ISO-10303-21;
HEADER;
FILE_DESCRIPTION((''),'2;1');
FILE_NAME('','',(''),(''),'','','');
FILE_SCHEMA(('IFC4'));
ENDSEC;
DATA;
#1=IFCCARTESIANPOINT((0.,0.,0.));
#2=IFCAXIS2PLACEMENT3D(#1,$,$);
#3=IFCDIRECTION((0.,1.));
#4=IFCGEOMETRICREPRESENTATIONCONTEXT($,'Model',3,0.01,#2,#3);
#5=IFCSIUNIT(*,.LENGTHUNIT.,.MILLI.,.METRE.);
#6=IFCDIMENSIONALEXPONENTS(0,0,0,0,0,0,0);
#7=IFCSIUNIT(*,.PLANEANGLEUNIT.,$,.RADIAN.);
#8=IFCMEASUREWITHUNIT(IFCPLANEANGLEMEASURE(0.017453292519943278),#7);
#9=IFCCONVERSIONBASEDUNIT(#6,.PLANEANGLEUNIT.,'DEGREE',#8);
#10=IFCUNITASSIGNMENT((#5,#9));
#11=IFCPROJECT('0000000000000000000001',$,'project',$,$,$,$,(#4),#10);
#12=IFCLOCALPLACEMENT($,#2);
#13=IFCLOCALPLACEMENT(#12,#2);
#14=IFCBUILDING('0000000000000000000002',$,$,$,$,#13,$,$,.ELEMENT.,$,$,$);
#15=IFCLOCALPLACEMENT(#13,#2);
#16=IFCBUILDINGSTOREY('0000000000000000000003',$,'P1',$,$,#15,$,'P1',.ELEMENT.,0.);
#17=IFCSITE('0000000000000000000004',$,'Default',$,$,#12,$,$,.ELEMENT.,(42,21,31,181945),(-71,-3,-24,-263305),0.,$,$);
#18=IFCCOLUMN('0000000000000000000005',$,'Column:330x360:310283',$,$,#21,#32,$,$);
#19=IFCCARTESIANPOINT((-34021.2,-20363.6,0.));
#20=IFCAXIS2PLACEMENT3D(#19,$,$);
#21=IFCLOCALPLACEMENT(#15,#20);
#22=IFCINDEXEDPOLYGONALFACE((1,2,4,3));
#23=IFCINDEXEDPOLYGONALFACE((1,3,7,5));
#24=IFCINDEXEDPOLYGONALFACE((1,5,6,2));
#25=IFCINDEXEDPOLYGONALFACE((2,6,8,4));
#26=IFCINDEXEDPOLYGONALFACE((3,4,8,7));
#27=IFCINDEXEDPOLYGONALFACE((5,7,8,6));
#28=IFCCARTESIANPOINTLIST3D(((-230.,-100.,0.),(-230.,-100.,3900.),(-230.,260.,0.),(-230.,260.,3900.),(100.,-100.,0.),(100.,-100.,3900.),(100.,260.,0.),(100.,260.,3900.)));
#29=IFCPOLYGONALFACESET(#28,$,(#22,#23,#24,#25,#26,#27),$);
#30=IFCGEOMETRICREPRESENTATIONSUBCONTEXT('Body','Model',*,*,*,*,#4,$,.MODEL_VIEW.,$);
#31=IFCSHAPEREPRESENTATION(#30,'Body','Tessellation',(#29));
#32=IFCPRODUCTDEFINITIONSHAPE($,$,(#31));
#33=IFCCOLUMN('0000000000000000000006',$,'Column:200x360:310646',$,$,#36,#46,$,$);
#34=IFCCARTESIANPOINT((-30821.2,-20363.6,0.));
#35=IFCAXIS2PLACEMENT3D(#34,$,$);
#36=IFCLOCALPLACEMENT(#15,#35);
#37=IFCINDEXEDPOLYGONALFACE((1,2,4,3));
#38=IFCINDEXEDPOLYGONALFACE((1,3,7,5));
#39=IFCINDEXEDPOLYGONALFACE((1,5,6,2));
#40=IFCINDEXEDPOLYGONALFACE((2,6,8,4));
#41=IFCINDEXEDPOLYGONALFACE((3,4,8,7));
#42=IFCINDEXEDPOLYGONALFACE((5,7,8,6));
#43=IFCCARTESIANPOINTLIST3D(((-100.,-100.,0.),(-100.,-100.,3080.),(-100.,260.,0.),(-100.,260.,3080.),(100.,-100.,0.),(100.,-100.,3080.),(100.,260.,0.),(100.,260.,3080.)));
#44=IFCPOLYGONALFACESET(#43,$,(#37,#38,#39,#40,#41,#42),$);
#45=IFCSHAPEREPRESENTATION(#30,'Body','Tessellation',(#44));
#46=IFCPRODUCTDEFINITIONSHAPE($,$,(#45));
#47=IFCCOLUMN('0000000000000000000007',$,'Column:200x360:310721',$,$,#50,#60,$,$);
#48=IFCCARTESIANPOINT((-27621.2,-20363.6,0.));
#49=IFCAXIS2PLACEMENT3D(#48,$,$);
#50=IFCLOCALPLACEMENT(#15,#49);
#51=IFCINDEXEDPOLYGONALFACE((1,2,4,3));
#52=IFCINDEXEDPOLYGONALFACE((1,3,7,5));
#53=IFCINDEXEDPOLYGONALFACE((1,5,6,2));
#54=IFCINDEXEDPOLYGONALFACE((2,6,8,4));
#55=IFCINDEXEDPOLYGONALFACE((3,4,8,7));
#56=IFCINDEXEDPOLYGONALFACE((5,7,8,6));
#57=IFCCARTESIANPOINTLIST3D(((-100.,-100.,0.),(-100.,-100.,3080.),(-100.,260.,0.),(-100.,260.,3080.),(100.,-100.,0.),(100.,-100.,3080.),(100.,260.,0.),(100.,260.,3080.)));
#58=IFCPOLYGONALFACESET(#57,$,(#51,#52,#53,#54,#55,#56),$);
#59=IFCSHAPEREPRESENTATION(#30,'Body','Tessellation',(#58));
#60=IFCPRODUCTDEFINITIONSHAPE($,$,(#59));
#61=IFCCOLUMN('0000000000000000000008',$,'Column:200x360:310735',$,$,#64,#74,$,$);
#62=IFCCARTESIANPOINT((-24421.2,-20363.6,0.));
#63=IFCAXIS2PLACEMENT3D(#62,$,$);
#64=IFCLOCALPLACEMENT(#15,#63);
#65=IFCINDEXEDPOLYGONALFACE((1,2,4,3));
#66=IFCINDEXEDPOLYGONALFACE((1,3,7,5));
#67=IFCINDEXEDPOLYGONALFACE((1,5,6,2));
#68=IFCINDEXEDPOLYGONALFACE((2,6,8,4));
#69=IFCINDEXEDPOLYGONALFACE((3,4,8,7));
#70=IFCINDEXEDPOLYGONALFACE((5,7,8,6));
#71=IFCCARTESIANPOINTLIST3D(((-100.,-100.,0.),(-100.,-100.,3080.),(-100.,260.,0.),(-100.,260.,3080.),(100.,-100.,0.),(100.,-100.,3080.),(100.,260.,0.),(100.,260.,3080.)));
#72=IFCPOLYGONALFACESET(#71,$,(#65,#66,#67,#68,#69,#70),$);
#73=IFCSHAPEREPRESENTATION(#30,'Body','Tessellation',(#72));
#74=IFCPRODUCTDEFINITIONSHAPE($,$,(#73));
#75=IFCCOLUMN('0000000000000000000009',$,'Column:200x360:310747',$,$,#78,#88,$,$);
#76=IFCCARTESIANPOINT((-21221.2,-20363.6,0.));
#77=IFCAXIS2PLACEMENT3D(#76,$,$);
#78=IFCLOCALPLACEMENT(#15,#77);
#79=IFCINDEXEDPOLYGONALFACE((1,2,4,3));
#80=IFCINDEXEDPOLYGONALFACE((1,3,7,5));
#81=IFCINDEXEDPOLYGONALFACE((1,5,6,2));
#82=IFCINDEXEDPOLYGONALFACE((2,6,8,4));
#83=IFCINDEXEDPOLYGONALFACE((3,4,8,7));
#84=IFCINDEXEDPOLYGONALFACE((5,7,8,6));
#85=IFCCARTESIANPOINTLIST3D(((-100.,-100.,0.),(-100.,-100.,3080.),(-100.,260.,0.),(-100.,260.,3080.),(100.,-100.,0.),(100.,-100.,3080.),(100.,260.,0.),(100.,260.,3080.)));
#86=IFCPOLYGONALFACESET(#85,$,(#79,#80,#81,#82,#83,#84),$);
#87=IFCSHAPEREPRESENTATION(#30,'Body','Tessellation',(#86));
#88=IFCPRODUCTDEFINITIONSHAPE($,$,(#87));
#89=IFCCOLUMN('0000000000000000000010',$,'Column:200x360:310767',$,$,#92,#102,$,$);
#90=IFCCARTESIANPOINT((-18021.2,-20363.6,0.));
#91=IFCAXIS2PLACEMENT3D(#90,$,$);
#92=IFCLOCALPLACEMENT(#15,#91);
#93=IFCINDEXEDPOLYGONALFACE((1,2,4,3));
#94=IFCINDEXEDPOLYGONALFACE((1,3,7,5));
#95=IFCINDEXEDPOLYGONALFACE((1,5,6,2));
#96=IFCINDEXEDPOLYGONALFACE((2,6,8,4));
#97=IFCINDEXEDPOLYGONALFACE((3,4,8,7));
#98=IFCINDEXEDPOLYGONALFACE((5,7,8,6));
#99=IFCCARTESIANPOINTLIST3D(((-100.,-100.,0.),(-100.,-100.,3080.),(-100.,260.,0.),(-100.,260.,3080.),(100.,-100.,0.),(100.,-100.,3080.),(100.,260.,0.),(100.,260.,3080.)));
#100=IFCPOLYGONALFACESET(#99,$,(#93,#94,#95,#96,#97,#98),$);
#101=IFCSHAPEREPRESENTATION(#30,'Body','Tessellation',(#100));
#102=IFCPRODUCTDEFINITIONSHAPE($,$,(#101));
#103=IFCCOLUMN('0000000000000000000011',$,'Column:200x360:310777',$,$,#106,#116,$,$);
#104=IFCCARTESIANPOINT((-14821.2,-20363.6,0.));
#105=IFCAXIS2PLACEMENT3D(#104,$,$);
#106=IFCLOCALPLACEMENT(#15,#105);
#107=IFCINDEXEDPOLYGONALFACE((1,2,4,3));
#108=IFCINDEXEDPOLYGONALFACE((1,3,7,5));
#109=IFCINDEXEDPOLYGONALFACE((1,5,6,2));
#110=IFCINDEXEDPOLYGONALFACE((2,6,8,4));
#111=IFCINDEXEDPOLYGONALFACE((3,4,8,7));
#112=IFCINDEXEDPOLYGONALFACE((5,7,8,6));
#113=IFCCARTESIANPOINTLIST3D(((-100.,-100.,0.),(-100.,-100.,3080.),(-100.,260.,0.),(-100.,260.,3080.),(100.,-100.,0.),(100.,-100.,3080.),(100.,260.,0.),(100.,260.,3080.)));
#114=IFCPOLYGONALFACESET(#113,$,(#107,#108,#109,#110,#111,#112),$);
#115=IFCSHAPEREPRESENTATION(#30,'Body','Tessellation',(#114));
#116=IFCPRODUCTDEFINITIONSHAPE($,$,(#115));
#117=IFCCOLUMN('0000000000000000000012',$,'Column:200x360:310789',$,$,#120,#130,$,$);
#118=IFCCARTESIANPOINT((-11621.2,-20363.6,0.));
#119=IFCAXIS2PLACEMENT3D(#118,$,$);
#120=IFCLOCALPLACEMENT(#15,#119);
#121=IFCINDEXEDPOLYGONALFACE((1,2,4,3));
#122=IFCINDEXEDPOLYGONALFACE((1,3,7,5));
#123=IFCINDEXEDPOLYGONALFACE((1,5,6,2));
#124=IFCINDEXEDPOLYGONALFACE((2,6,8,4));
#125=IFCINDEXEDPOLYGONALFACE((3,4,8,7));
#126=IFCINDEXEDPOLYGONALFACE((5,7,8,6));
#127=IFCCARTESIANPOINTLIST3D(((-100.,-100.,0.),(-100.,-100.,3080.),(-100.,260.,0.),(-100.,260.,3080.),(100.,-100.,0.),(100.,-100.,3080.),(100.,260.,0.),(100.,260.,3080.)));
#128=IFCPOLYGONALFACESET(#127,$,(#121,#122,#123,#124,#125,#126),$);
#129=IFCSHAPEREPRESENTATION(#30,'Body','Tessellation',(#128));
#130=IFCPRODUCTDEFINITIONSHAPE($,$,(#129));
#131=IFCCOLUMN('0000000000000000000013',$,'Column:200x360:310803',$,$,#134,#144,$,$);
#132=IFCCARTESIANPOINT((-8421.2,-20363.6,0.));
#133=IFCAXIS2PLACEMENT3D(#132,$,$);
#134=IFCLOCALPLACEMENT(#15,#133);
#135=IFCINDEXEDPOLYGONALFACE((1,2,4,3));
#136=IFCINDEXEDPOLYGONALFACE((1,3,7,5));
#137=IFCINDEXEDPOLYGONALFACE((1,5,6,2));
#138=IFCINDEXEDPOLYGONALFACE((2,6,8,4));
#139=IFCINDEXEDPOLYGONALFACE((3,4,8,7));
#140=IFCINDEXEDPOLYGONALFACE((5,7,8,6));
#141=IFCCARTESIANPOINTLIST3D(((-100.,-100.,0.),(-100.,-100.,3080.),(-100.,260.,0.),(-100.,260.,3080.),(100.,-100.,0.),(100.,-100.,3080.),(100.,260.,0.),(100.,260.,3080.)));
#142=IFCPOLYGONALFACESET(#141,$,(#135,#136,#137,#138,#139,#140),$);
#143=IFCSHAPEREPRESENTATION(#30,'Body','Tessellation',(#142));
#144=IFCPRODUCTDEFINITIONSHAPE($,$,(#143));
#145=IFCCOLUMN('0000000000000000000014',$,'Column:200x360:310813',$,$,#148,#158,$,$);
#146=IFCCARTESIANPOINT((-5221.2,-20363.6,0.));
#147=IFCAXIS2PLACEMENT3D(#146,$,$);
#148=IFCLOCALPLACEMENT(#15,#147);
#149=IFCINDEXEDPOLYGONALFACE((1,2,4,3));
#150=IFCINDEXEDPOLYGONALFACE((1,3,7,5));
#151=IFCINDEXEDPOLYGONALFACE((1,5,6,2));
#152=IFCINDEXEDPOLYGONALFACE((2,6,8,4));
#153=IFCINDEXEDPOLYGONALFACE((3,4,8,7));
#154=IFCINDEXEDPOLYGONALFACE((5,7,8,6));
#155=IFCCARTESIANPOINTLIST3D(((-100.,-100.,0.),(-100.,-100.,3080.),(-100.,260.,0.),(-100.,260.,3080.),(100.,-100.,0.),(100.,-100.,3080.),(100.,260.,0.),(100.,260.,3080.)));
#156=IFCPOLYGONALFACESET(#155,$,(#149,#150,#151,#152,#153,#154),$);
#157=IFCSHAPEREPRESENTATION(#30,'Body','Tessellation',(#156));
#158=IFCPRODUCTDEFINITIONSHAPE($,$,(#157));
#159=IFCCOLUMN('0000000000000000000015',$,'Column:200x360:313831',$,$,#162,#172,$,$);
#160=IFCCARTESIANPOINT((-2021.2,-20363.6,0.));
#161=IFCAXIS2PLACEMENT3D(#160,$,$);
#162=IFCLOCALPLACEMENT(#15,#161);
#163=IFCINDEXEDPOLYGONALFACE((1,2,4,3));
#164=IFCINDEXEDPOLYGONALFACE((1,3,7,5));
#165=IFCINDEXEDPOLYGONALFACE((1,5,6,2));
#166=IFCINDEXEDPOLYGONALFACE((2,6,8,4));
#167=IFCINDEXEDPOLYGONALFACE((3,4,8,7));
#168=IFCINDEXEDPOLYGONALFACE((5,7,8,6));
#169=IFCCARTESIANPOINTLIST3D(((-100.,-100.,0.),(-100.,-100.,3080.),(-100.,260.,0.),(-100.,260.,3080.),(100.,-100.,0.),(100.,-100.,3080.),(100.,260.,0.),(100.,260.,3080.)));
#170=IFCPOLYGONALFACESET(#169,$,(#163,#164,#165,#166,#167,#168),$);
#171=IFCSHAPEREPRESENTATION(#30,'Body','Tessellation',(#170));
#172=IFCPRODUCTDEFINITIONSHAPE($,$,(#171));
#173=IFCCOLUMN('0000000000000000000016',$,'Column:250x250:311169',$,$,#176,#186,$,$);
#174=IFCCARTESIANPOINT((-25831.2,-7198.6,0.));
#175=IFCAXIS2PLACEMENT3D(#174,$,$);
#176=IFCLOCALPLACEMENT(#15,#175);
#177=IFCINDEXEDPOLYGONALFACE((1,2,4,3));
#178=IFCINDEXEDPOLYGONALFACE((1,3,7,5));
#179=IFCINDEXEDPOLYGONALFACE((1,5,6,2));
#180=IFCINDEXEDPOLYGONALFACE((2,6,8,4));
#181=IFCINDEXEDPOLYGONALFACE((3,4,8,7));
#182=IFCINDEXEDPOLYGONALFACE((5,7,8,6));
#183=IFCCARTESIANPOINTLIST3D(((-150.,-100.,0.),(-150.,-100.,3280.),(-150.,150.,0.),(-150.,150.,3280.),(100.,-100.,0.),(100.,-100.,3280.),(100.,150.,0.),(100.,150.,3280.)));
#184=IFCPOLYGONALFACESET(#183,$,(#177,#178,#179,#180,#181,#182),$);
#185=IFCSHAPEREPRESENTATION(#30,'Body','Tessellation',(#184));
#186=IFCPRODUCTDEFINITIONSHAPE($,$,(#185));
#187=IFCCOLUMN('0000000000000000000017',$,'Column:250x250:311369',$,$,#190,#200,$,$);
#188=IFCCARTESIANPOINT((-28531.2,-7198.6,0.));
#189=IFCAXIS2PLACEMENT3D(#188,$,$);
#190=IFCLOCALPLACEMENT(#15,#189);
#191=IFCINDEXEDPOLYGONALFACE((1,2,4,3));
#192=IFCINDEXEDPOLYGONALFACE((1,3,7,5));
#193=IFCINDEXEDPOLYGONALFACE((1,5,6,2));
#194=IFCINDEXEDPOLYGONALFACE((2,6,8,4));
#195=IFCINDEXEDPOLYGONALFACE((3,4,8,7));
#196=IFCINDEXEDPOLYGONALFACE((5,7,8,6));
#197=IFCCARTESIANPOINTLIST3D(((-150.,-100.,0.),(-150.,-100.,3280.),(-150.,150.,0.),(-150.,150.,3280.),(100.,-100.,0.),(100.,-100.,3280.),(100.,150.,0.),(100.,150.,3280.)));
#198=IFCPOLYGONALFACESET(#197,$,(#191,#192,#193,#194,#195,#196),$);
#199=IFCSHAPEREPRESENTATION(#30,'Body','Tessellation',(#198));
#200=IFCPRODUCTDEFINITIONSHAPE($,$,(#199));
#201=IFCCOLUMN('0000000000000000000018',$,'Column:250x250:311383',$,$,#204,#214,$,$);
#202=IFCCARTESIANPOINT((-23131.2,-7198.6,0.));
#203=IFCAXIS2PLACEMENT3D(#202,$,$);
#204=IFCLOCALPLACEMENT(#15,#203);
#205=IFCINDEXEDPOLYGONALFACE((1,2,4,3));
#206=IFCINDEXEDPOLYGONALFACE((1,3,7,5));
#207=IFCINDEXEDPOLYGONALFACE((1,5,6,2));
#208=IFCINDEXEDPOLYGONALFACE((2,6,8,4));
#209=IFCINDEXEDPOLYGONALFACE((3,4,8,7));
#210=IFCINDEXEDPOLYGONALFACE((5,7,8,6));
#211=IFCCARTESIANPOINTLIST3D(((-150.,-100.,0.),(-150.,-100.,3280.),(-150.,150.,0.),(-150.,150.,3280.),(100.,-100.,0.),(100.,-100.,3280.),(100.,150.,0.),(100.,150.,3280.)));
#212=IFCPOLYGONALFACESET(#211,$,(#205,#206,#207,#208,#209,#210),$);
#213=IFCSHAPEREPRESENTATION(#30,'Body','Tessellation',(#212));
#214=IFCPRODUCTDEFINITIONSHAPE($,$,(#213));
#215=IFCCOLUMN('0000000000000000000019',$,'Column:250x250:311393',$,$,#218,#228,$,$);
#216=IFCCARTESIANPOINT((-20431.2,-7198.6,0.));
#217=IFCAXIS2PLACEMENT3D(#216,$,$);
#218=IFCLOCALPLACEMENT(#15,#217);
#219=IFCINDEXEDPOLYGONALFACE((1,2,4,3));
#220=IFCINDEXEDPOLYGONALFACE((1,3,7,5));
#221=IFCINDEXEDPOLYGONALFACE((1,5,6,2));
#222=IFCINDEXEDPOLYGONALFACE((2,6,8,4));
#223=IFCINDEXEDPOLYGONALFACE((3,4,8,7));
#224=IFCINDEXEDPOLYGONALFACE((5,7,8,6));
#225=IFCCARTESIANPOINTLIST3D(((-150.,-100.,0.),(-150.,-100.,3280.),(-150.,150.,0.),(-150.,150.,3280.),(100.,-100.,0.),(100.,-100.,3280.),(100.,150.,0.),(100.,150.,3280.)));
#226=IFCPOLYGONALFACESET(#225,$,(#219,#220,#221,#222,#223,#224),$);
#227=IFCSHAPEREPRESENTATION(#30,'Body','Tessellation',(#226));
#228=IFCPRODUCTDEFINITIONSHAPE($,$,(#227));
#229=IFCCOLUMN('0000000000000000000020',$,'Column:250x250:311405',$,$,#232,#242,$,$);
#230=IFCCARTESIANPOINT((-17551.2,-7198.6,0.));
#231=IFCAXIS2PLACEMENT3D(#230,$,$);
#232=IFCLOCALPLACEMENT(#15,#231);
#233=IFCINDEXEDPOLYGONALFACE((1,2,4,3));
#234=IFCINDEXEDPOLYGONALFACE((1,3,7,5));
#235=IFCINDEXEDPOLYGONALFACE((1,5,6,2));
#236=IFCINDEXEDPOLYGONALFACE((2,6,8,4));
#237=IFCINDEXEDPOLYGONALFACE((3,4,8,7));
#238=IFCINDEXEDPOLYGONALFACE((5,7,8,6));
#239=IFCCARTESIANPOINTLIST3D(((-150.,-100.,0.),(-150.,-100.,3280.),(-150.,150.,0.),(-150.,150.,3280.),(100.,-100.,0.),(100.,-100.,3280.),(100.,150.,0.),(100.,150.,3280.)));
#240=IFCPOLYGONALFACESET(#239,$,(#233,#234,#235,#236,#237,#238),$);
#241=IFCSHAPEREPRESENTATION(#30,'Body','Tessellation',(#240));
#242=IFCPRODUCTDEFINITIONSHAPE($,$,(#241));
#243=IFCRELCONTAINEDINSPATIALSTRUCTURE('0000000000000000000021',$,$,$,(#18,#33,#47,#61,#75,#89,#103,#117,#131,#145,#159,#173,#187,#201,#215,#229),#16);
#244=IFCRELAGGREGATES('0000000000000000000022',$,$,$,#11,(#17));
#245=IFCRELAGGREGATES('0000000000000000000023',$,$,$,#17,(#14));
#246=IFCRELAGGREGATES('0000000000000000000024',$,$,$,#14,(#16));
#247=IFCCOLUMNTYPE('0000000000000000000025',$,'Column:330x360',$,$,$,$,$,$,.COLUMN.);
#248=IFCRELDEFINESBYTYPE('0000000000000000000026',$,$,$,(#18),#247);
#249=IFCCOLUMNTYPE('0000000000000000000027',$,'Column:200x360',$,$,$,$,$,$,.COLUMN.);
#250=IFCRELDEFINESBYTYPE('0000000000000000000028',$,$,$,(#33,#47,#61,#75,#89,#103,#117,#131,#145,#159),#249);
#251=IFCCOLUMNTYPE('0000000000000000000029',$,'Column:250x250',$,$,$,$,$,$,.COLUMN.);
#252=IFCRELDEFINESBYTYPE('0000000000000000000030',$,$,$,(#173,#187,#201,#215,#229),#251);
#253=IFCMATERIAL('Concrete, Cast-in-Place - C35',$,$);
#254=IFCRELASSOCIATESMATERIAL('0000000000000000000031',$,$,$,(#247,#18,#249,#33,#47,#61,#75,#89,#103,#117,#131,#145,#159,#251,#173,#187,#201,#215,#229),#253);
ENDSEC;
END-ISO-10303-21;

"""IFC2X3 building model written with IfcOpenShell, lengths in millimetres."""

from ifc_helpers import new_model, entity, si_unit, converted_unit, direction, frame, origin, origin_2d_with_axis, place, context, subcontext, project, spatial, rectangle, extrude, source, transform, mapped, material, type_object, type_shapes, element, save


model = new_model("IFC2X3")

# Units and contexts
model_context = context("Model", 3, precision=0.01, world=origin(), true_north=direction((0.0, 1.0)))
body_context = subcontext(model_context, "Body", "Model", "MODEL_VIEW")
ifc_project = project(units=[si_unit("LENGTHUNIT", "METRE", prefix="MILLI"), converted_unit("PLANEANGLEUNIT", "DEGREE", entity("IfcPlaneAngleMeasure", 0.017453292519943278), si_unit("PLANEANGLEUNIT", "RADIAN"), dimensions=[0, 0, 0, 0, 0, 0, 0])], contexts=[model_context])

# Site, building, storey
site_placement = place(None, origin())
site = spatial("IfcSite", under=ifc_project, at=site_placement, Name="Default", CompositionType="ELEMENT", RefLatitude=(42, 21, 31, 181945), RefLongitude=(-71, -3, -24, -263305), RefElevation=0.0)
building_placement = place(site_placement, origin())
building = spatial("IfcBuilding", under=site, at=building_placement, CompositionType="ELEMENT")
storey_placement = place(building_placement, origin())
storey = spatial("IfcBuildingStorey", under=building, at=storey_placement, Name="P1", LongName="P1", CompositionType="ELEMENT", Elevation=0.0)

# Columns
ifc_material = material(Name="Concrete, Cast-in-Place - C35")
column_type_1 = type_object("IfcColumnType", Name="Column:330x360", PredefinedType="COLUMN", material=ifc_material)
shared_shape_1 = source(origin(), body_context, "Body", "SweptSolid", [
    extrude(rectangle(XDim=330.0, YDim=360.0, at=origin_2d_with_axis()), frame((-65.0, 80.0, 0.0), z_axis=(0.0, 0.0, 1.0), x_axis=(-1.0, 0.0, 0.0)), (0.0, 0.0, 1.0), 3900.0),
])
type_shapes(column_type_1, [shared_shape_1])
column_placement = place(storey_placement, frame((-34021.2, -20363.6, 0.0)))
element("IfcColumn", 1, at=column_placement, inside=storey, type_object=column_type_1, material=ifc_material, Name="Column:330x360:310283", context=body_context, shape_type="MappedRepresentation", body=[
    mapped(shared_shape_1, transform((0.0, 0.0, 0.0), scale=1.0)),
])
column_type_2 = type_object("IfcColumnType", Name="Column:200x360", PredefinedType="COLUMN", material=ifc_material)
shared_shape_2 = source(origin(), body_context, "Body", "SweptSolid", [
    extrude(rectangle(XDim=200.0, YDim=360.0, at=origin_2d_with_axis()), frame((0.0, 80.0, 0.0), z_axis=(0.0, 0.0, 1.0), x_axis=(-1.0, 0.0, 0.0)), (0.0, 0.0, 1.0), 3080.0),
])
type_shapes(column_type_2, [shared_shape_2])
for number, where, name in (
    (2, (-30821.2, -20363.6, 0.0), "Column:200x360:310646"),
    (3, (-27621.2, -20363.6, 0.0), "Column:200x360:310721"),
    (4, (-24421.2, -20363.6, 0.0), "Column:200x360:310735"),
    (5, (-21221.2, -20363.6, 0.0), "Column:200x360:310747"),
    (6, (-18021.2, -20363.6, 0.0), "Column:200x360:310767"),
    (7, (-14821.2, -20363.6, 0.0), "Column:200x360:310777"),
    (8, (-11621.2, -20363.6, 0.0), "Column:200x360:310789"),
    (9, (-8421.2, -20363.6, 0.0), "Column:200x360:310803"),
    (10, (-5221.2, -20363.6, 0.0), "Column:200x360:310813"),
    (11, (-2021.2, -20363.6, 0.0), "Column:200x360:313831"),
):
    element("IfcColumn", number, at=place(storey_placement, frame(where)), inside=storey, type_object=column_type_2, material=ifc_material, Name=name, context=body_context, shape_type="MappedRepresentation", body=[
        mapped(shared_shape_2, transform((0.0, 0.0, 0.0), scale=1.0)),
    ])
column_type_3 = type_object("IfcColumnType", Name="Column:250x250", PredefinedType="COLUMN", material=ifc_material)
shared_shape_3 = source(origin(), body_context, "Body", "SweptSolid", [
    extrude(rectangle(XDim=250.0, YDim=250.0, at=origin_2d_with_axis()), frame((-25.0, 25.0, 0.0), z_axis=(0.0, 0.0, 1.0), x_axis=(-1.0, 0.0, 0.0)), (0.0, 0.0, 1.0), 3280.0),
])
type_shapes(column_type_3, [shared_shape_3])
for number, where, name in (
    (12, (-25831.2, -7198.6, 0.0), "Column:250x250:311169"),
    (13, (-28531.2, -7198.6, 0.0), "Column:250x250:311369"),
    (14, (-23131.2, -7198.6, 0.0), "Column:250x250:311383"),
    (15, (-20431.2, -7198.6, 0.0), "Column:250x250:311393"),
    (16, (-17551.2, -7198.6, 0.0), "Column:250x250:311405"),
):
    element("IfcColumn", number, at=place(storey_placement, frame(where)), inside=storey, type_object=column_type_3, material=ifc_material, Name=name, context=body_context, shape_type="MappedRepresentation", body=[
        mapped(shared_shape_3, transform((0.0, 0.0, 0.0), scale=1.0)),
    ])

save(model, "model.ifc")
